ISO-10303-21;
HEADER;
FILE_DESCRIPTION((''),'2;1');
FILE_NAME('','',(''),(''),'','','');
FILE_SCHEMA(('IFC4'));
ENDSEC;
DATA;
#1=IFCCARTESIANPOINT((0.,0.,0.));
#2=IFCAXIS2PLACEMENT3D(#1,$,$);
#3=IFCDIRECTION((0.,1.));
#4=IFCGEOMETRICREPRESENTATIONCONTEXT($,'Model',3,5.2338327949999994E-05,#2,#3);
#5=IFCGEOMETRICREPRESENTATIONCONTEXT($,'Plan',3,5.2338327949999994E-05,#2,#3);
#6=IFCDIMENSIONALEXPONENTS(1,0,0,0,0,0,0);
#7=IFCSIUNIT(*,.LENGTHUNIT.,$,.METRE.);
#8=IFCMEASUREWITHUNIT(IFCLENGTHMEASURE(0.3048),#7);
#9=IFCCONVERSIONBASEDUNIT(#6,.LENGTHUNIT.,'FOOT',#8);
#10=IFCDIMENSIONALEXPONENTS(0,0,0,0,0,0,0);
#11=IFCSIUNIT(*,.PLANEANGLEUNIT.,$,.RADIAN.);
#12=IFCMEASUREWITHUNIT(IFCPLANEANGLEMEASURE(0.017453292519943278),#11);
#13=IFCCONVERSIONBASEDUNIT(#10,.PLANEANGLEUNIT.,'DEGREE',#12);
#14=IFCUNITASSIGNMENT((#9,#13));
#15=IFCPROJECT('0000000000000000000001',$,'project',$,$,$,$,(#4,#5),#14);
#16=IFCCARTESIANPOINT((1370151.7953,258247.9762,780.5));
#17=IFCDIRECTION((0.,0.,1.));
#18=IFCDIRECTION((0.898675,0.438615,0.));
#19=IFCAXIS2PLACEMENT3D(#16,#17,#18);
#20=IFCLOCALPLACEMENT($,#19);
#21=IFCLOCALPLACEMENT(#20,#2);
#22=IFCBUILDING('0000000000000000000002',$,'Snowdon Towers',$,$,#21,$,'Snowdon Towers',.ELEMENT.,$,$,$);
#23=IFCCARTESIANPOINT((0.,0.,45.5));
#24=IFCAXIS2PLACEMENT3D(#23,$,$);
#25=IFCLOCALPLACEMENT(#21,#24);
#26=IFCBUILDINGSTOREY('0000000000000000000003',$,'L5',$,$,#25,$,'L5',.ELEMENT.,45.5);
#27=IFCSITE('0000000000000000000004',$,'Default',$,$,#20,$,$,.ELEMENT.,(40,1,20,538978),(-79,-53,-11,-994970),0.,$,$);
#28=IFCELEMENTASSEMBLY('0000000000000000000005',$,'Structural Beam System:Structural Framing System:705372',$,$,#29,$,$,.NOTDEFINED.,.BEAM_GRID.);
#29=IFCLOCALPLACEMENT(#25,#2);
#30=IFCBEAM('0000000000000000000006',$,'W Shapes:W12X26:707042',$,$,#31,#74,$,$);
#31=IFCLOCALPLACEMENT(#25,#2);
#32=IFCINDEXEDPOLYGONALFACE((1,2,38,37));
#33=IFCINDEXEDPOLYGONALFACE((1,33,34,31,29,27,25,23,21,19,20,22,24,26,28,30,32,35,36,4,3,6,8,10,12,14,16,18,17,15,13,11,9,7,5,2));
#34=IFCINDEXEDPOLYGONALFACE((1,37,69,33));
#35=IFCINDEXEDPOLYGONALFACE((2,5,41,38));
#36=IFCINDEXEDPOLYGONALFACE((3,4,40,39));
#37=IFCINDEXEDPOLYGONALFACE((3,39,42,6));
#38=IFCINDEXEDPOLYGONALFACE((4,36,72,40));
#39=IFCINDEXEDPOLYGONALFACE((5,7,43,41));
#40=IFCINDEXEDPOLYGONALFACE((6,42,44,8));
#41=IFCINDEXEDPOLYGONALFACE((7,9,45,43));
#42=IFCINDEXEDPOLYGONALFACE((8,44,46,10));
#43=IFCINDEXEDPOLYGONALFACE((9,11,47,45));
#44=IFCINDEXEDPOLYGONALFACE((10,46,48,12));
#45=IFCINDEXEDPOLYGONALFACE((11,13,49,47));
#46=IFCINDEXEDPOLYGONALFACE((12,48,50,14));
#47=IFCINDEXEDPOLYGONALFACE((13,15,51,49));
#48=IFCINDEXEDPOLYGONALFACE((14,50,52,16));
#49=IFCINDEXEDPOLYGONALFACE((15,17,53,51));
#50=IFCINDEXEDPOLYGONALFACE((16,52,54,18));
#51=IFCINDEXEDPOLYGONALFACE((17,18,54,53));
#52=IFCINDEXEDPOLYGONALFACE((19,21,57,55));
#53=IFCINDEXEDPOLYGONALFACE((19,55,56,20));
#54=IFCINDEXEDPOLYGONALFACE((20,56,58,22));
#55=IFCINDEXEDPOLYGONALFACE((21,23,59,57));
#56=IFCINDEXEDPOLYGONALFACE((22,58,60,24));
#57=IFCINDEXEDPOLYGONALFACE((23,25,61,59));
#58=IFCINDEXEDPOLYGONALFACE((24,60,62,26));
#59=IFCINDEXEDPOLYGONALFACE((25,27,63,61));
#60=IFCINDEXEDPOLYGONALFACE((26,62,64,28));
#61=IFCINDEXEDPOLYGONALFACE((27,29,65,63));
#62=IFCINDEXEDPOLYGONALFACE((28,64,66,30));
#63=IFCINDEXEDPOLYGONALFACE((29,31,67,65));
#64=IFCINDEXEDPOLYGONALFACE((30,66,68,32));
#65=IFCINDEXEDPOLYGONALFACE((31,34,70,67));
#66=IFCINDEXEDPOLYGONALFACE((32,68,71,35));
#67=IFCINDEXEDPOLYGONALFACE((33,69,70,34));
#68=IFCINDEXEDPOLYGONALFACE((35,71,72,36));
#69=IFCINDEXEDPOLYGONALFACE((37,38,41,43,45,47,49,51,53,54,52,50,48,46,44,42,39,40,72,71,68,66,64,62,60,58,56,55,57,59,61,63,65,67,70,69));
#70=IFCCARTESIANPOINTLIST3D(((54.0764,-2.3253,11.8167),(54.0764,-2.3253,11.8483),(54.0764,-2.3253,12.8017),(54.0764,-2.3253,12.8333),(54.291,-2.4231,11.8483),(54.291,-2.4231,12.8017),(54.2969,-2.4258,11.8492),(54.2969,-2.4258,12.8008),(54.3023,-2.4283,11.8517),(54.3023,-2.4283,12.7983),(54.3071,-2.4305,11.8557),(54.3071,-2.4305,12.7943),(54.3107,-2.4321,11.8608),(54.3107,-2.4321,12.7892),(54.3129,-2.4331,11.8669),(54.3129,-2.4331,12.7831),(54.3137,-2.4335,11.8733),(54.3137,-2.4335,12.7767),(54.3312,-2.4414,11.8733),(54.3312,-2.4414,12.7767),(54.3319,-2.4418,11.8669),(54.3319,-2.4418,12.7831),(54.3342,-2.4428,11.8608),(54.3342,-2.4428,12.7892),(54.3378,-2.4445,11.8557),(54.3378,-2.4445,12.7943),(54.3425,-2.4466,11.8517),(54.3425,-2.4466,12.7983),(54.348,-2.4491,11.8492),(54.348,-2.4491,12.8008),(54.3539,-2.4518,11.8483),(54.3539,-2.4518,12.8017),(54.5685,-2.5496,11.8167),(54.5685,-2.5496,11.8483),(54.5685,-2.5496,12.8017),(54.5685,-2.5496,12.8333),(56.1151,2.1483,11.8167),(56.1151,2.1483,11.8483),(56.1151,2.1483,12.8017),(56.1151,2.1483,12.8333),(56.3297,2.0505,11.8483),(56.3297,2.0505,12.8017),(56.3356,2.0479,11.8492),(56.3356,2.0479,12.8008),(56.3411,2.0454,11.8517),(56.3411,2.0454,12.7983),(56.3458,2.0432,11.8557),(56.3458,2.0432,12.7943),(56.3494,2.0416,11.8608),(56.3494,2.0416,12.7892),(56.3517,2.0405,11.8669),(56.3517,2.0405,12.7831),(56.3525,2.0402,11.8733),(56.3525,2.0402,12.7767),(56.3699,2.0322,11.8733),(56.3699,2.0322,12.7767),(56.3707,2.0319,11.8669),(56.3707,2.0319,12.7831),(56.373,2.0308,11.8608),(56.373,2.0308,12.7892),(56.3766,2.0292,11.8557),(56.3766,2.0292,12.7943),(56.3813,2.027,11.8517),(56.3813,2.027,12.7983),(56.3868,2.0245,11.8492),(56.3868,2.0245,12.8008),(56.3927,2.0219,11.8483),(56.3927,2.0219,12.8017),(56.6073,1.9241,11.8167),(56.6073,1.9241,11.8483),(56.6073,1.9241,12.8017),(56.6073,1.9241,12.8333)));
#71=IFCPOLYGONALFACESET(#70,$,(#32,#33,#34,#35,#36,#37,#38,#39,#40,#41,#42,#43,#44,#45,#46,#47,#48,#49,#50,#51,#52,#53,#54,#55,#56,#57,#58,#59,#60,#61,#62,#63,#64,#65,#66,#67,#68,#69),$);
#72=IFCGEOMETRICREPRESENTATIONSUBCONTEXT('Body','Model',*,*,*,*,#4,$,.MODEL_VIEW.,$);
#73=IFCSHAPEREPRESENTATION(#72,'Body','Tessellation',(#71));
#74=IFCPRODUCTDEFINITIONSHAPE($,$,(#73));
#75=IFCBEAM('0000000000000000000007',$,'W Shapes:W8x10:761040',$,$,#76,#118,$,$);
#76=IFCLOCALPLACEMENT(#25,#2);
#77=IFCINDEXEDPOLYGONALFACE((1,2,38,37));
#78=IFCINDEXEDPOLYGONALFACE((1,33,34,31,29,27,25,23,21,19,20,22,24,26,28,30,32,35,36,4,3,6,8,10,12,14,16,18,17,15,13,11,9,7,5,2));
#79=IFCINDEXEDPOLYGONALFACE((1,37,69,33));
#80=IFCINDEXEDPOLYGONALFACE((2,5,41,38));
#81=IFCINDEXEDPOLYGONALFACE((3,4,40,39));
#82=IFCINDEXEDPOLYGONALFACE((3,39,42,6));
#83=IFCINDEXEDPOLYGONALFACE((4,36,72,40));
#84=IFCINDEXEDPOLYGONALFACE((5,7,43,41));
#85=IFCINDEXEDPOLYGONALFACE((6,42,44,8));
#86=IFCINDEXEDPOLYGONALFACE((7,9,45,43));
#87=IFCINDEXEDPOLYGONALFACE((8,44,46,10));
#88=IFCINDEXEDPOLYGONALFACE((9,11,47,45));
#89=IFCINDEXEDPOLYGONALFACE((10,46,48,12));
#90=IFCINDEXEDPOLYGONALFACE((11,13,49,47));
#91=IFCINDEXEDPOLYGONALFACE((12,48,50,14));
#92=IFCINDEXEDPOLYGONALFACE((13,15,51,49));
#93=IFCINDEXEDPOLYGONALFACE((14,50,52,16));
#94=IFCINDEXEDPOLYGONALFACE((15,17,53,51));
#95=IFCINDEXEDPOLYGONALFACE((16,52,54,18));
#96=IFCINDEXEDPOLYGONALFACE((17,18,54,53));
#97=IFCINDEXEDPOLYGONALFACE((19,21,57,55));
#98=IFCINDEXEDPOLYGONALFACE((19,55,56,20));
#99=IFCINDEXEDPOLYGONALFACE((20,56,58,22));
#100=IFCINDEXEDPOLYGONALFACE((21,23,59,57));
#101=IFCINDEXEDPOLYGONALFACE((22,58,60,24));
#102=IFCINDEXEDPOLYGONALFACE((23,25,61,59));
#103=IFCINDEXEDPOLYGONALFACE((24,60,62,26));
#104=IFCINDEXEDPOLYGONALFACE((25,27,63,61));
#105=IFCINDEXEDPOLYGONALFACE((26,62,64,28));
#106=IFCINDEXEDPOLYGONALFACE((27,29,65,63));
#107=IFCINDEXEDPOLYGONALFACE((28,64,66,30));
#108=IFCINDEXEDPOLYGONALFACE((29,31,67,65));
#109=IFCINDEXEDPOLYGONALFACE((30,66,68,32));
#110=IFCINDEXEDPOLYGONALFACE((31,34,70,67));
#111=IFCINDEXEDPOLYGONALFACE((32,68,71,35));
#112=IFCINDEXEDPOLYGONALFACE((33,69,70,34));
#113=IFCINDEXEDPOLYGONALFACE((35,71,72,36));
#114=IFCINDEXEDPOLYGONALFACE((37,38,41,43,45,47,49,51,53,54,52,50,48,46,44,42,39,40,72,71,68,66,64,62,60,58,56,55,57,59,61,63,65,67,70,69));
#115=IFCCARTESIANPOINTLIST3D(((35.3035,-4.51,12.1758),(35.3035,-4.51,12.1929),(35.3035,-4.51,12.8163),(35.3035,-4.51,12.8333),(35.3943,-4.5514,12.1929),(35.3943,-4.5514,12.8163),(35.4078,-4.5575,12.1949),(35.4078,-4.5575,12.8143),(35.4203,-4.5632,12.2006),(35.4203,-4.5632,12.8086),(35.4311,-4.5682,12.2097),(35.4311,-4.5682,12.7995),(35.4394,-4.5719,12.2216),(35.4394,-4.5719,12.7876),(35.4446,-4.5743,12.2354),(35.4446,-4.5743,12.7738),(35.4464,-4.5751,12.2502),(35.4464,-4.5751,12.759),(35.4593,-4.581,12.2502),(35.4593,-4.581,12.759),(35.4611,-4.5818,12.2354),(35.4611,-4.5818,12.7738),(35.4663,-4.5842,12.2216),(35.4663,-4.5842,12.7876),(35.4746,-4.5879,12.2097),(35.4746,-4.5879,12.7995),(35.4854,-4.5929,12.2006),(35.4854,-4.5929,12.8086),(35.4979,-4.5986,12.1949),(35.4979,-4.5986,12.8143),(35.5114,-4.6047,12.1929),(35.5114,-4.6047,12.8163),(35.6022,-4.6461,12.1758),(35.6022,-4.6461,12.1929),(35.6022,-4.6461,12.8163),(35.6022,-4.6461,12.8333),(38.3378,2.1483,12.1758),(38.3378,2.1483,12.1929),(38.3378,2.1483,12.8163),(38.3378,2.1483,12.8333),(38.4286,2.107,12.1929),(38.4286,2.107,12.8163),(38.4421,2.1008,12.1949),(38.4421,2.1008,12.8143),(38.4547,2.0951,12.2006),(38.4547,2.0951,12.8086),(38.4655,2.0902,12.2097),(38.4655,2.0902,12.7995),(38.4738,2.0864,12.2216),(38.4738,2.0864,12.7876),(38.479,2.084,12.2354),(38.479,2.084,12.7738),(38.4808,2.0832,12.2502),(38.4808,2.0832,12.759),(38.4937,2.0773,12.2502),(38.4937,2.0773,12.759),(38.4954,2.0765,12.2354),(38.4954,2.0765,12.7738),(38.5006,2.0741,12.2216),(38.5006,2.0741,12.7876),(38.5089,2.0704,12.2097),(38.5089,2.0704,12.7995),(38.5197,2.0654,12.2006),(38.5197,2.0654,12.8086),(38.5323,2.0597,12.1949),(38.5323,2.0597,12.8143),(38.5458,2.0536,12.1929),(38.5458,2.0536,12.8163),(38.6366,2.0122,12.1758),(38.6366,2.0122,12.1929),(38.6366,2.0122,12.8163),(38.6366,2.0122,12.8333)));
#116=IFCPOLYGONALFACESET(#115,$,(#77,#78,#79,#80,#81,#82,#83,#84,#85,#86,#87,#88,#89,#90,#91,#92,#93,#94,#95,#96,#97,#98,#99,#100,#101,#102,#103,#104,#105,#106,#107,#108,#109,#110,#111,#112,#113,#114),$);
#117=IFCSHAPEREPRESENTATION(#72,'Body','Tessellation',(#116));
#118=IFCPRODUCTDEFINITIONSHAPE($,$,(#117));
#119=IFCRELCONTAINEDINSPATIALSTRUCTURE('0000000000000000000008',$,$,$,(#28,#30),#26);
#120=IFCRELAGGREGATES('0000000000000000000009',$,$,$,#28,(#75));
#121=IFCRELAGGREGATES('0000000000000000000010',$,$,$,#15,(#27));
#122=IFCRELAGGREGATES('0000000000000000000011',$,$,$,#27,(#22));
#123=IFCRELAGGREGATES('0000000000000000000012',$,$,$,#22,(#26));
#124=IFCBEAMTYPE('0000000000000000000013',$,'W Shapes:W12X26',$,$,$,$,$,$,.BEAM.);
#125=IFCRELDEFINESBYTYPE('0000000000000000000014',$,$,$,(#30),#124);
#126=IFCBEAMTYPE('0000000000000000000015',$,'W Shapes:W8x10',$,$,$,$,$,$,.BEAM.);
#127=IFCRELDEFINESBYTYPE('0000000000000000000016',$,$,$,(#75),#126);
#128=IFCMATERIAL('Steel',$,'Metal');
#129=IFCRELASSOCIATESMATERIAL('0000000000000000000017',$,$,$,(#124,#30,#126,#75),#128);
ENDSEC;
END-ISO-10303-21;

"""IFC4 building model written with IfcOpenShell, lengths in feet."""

from ifc_helpers import new_model, entity, si_unit, converted_unit, direction, frame, origin, place, context, subcontext, project, spatial, line, arc, indexed_curve, outline, extrude, source, transform, mapped, material, type_object, type_shapes, element, aggregate, save


model = new_model("IFC4")

# Units and contexts
model_context = context("Model", 3, precision=5.2338327949999994e-05, world=origin(), true_north=direction((0.0, 1.0)))
plan_context = context("Plan", 3, precision=5.2338327949999994e-05, world=origin(), true_north=direction((0.0, 1.0)))
body_context = subcontext(model_context, "Body", "Model", "MODEL_VIEW")
ifc_project = project(units=[converted_unit("LENGTHUNIT", "FOOT", entity("IfcLengthMeasure", 0.3048), si_unit("LENGTHUNIT", "METRE"), dimensions=[1, 0, 0, 0, 0, 0, 0]), converted_unit("PLANEANGLEUNIT", "DEGREE", entity("IfcPlaneAngleMeasure", 0.017453292519943278), si_unit("PLANEANGLEUNIT", "RADIAN"), dimensions=[0, 0, 0, 0, 0, 0, 0])], contexts=[model_context, plan_context])

# Site, building, storey
site_placement = place(None, frame((1370151.7953, 258247.9762, 780.5), z_axis=(0.0, 0.0, 1.0), x_axis=(0.898675, 0.438615, 0.0)))
site = spatial("IfcSite", under=ifc_project, at=site_placement, Name="Default", CompositionType="ELEMENT", RefLatitude=(40, 1, 20, 538978), RefLongitude=(-79, -53, -11, -994970), RefElevation=0.0)
building_placement = place(site_placement, origin())
building = spatial("IfcBuilding", under=site, at=building_placement, Name="Snowdon Towers", LongName="Snowdon Towers", CompositionType="ELEMENT")
storey_placement = place(building_placement, frame((0.0, 0.0, 45.5)))
storey = spatial("IfcBuildingStorey", under=building, at=storey_placement, Name="L5", LongName="L5", CompositionType="ELEMENT", Elevation=45.5)

# Shared definitions
ifc_material = material(Name="Steel", Category="Metal")

# Element assembly
assembly_1_placement = place(storey_placement, origin())
assembly_1 = element("IfcElementAssembly", 1, at=assembly_1_placement, inside=storey, Name="Structural Beam System:Structural Framing System:705372", AssemblyPlace="NOTDEFINED", PredefinedType="BEAM_GRID")

# Beams
beam_type_1 = type_object("IfcBeamType", Name="W Shapes:W12X26", PredefinedType="BEAM", material=ifc_material)
shared_shape_1 = source(origin(), body_context, "Body", "SweptSolid", [
    extrude(outline(indexed_curve([(-0.5083, -0.2704), (-0.4767, -0.2704), (-0.4767, -0.0346), (-0.4693, -0.0169), (-0.4517, -0.0096), (0.4517, -0.0096), (0.4693, -0.0169), (0.4767, -0.0346), (0.4767, -0.2704), (0.5083, -0.2704), (0.5083, 0.2704), (0.4767, 0.2704), (0.4767, 0.0346), (0.4693, 0.0169), (0.4517, 0.0096), (-0.4517, 0.0096), (-0.4693, 0.0169), (-0.4767, 0.0346), (-0.4767, 0.2704), (-0.5083, 0.2704)], segments=[line(1, 2, 3), arc(3, 4, 5), line(5, 6), arc(6, 7, 8), line(8, 9, 10, 11, 12, 13), arc(13, 14, 15), line(15, 16), arc(16, 17, 18), line(18, 19, 20, 1)], self_intersect=False)), frame((-2.557, 0.0, 0.0), z_axis=(1.0, 0.0, 0.0), x_axis=(0.0, 0.0, -1.0)), (0.0, 0.0, 1.0), 4.9163),
])
type_shapes(beam_type_1, [shared_shape_1])
beam_1_placement = place(storey_placement, frame((55.3828, -0.1107, 12.325), z_axis=(0.0, 0.0, 1.0), x_axis=(0.414693, 0.909961, 0.0)))
element("IfcBeam", 2, at=beam_1_placement, inside=storey, type_object=beam_type_1, material=ifc_material, Name="W Shapes:W12X26:707042", context=body_context, shape_type="MappedRepresentation", body=[
    mapped(shared_shape_1, transform((0.0, 0.0, 0.0), scale=1.0)),
])
beam_type_2 = type_object("IfcBeamType", Name="W Shapes:W8x10", PredefinedType="BEAM", material=ifc_material)
shared_shape_2 = source(origin(), body_context, "Body", "SweptSolid", [
    extrude(outline(indexed_curve([(-0.3287, -0.1642), (-0.3117, -0.1642), (-0.3117, -0.0644), (-0.2949, -0.0239), (-0.2544, -0.0071), (0.2544, -0.0071), (0.2949, -0.0239), (0.3117, -0.0644), (0.3117, -0.1642), (0.3288, -0.1642), (0.3288, 0.1642), (0.3117, 0.1642), (0.3117, 0.0644), (0.2949, 0.0239), (0.2544, 0.0071), (-0.2544, 0.0071), (-0.2949, 0.0239), (-0.3117, 0.0644), (-0.3117, 0.1642), (-0.3287, 0.1642)], segments=[line(1, 2, 3), arc(3, 4, 5), line(5, 6), arc(6, 7, 8), line(8, 9, 10, 11, 12, 13), arc(13, 14, 15), line(15, 16), arc(16, 17, 18), line(18, 19, 20, 1)], self_intersect=False)), frame((-3.7332, 0.0, 0.0), z_axis=(1.0, 0.0, 0.0), x_axis=(0.0, 0.0, -1.0)), (0.0, 0.0, 1.0), 7.3171),
])
type_shapes(beam_type_2, [shared_shape_2])
beam_2_placement = place(assembly_1_placement, frame((37.001, -1.181, 12.5046), z_axis=(0.0, 0.0, 1.0), x_axis=(0.414693, 0.909961, 0.0)))
beam_2 = element("IfcBeam", 3, at=beam_2_placement, type_object=beam_type_2, material=ifc_material, Name="W Shapes:W8x10:761040", context=body_context, shape_type="MappedRepresentation", body=[
    mapped(shared_shape_2, transform((0.0, 0.0, 0.0), scale=1.0)),
])
aggregate(assembly_1, [beam_2])

save(model, "model.ifc")
